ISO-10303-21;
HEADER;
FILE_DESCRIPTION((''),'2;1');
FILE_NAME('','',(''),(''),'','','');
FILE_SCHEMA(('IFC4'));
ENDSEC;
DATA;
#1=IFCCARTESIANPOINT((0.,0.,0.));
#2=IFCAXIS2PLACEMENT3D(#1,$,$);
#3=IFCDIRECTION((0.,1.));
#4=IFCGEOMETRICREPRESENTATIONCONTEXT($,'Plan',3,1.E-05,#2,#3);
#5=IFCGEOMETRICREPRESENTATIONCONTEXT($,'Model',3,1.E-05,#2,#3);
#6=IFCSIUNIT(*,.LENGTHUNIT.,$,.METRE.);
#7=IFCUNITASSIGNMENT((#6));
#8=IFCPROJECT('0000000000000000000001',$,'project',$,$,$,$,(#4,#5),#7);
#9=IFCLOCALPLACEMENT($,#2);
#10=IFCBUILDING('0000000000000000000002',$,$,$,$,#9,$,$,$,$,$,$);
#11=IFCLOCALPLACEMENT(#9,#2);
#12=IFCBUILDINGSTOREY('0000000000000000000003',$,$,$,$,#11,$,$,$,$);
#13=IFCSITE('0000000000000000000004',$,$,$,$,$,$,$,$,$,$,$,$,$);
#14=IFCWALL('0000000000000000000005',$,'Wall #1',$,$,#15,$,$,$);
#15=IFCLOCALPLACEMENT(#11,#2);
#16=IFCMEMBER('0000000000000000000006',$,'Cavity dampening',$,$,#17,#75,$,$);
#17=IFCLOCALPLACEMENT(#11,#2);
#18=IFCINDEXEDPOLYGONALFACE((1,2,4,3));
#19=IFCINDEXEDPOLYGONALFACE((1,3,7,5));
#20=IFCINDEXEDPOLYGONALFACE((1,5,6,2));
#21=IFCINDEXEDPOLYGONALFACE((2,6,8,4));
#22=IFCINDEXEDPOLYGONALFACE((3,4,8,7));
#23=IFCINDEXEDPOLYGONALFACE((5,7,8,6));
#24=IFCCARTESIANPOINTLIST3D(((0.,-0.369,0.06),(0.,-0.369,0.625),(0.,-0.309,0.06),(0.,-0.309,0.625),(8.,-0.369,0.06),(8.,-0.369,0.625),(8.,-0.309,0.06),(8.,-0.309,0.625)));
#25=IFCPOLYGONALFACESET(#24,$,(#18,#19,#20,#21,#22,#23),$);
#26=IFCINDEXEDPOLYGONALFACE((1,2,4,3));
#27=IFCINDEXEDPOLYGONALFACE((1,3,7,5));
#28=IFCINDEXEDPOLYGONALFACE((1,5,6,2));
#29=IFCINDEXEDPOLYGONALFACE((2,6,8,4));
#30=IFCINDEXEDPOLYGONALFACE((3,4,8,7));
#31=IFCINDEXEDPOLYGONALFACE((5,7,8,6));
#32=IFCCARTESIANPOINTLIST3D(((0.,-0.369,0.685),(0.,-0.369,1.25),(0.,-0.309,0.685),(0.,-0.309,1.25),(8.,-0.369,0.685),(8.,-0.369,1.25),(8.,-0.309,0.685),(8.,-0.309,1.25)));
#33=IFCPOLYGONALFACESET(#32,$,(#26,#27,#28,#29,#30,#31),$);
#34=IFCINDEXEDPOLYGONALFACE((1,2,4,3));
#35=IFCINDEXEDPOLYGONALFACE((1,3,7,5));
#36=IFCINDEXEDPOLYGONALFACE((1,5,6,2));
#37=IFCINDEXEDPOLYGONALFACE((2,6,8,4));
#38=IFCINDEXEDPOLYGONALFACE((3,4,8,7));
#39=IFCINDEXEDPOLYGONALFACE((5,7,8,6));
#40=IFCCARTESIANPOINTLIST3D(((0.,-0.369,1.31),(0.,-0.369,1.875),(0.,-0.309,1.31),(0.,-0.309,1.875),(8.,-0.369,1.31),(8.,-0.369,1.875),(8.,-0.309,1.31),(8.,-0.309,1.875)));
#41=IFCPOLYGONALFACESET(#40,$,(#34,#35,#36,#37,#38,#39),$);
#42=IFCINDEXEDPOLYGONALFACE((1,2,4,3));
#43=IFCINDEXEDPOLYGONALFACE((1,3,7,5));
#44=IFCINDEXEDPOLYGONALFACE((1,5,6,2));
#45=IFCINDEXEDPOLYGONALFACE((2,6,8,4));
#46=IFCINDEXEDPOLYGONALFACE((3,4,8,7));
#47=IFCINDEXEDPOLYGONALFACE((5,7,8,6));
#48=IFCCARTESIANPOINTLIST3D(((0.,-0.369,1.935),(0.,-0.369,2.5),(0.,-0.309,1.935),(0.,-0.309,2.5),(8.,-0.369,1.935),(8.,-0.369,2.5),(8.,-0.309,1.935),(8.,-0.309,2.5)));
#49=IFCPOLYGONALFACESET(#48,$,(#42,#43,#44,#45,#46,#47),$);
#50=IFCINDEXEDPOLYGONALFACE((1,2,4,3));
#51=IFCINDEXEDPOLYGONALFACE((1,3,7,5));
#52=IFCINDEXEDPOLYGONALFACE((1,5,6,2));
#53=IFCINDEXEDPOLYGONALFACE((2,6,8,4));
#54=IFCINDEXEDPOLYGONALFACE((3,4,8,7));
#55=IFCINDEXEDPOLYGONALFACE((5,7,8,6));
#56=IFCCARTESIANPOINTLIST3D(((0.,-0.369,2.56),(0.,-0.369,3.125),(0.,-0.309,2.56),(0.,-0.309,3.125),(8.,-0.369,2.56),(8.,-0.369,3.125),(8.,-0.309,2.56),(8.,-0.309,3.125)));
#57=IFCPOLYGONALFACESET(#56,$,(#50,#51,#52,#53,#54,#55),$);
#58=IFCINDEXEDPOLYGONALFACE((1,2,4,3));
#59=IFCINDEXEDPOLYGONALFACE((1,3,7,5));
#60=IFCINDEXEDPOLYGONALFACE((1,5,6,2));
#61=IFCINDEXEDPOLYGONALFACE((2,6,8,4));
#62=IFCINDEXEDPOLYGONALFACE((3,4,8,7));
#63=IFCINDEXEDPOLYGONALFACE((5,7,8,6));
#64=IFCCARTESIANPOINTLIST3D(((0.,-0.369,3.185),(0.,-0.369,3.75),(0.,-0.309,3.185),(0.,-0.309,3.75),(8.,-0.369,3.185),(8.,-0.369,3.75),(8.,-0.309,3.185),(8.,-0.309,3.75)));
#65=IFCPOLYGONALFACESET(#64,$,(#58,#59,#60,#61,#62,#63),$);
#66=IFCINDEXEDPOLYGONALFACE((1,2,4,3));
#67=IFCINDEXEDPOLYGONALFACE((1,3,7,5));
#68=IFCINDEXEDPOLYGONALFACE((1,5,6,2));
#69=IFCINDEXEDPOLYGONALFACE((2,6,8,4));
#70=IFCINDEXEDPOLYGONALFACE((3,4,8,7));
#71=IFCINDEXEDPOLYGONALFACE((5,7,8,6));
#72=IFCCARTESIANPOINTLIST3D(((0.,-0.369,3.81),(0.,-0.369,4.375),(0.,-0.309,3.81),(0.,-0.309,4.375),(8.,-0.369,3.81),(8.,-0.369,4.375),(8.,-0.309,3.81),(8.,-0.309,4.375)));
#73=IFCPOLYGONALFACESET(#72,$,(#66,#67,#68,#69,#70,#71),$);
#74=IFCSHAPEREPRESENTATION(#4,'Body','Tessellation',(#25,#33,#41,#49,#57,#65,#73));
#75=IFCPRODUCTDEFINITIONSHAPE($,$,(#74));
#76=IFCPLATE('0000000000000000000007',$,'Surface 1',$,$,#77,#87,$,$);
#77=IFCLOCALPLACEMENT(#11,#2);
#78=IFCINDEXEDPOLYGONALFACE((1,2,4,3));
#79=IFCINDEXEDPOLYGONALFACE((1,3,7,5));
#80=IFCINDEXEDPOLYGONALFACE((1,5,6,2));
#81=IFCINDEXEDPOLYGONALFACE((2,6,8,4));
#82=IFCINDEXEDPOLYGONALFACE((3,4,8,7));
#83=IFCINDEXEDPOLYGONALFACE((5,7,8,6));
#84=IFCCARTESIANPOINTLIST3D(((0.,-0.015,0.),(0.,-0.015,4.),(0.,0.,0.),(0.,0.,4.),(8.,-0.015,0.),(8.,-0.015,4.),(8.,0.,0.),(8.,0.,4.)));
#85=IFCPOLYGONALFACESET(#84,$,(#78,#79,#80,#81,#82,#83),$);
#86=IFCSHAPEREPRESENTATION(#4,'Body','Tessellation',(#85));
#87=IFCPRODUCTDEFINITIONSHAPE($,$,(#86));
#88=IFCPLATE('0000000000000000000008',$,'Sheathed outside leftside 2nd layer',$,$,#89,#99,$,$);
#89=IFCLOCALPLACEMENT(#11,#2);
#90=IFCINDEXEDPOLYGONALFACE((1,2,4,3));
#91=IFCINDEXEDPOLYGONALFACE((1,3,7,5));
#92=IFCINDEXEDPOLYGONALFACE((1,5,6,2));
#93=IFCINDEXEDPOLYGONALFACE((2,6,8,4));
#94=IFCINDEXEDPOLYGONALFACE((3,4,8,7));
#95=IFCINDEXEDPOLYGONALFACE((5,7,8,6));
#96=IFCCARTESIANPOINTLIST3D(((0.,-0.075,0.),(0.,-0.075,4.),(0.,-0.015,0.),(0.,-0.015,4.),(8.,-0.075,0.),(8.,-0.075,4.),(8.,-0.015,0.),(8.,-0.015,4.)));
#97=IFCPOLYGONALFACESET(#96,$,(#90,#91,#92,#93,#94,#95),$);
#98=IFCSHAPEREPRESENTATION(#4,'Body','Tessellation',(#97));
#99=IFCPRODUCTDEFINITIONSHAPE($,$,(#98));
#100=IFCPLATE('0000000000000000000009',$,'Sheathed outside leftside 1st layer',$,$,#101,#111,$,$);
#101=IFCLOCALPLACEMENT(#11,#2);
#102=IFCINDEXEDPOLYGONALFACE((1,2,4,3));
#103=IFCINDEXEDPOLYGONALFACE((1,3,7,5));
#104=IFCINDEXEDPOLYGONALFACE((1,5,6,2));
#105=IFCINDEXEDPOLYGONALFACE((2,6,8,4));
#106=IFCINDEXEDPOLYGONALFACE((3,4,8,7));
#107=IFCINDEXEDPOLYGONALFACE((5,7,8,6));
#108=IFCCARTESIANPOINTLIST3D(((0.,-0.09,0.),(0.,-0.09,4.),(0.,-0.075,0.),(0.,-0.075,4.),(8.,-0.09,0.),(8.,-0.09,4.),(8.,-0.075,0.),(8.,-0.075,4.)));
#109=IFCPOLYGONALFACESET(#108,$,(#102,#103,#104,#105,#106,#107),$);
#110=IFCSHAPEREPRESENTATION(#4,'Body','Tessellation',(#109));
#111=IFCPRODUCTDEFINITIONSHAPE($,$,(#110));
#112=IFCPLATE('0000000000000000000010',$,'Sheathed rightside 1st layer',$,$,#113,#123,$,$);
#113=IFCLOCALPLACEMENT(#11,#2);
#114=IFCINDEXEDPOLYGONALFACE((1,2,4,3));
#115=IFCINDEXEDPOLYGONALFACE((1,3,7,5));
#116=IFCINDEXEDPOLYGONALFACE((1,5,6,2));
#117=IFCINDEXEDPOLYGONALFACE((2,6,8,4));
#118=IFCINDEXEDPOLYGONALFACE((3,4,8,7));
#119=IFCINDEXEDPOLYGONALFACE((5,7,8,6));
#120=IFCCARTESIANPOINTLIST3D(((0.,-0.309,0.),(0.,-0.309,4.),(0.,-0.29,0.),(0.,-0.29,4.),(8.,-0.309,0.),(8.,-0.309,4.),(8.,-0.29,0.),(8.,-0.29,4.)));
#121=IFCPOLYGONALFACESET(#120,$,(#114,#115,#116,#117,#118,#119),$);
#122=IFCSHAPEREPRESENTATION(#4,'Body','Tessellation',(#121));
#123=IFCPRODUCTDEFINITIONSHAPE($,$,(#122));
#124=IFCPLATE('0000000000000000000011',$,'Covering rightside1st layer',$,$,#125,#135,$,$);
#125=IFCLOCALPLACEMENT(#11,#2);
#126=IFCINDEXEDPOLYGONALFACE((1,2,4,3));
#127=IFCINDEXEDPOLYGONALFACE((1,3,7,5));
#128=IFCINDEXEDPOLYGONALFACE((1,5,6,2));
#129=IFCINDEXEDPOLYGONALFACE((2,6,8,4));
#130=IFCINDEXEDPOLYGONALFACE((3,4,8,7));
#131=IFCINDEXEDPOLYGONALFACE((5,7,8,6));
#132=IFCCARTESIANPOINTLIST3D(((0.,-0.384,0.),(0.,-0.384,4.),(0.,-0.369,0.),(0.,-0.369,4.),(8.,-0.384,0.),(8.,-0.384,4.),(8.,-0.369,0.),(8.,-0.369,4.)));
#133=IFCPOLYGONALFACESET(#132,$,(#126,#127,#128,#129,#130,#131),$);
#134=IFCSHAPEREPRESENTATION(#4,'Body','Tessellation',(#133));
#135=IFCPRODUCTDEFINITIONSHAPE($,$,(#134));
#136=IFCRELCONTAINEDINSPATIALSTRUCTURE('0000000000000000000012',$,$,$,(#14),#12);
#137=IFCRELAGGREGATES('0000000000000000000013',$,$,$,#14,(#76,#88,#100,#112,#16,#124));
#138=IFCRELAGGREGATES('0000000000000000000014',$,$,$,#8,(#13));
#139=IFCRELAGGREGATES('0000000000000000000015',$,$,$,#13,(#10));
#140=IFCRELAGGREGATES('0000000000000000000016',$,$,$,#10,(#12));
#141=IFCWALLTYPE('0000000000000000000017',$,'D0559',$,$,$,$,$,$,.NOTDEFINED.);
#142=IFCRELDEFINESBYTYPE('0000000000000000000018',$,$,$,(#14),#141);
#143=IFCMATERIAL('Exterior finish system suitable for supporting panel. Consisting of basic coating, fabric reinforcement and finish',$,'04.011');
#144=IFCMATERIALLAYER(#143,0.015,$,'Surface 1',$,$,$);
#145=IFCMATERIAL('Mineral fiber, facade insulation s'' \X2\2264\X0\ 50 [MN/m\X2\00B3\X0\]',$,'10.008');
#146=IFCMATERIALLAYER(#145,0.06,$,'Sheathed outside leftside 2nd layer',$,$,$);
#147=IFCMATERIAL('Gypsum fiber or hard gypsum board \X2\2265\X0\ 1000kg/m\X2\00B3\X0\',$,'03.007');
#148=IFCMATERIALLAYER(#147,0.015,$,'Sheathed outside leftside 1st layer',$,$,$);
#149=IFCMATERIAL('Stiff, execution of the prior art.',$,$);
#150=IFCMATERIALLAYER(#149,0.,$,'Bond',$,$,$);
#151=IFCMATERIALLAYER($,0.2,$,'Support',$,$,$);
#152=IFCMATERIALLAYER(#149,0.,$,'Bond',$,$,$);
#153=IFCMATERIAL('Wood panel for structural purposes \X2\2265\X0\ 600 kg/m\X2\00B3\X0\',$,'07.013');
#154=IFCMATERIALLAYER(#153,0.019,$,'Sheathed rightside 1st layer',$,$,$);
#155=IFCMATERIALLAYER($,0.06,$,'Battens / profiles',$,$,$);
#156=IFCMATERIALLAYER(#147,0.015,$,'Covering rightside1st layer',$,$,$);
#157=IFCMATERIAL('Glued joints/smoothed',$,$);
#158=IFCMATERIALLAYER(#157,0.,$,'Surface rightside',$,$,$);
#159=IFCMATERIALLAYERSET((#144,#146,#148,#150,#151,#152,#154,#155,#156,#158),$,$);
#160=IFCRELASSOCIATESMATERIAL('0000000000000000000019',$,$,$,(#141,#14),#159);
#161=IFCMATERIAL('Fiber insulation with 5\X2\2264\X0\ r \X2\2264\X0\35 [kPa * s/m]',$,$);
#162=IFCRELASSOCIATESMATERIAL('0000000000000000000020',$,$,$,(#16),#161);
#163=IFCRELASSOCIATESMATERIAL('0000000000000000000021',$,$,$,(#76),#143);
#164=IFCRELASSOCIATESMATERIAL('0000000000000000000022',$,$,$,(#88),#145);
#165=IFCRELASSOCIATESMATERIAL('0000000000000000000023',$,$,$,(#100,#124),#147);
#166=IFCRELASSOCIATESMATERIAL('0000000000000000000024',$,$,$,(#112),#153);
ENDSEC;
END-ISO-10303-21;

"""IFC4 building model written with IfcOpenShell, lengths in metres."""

from ifc_helpers import new_model, si_unit, direction, frame, frame_2d, origin, origin_with_axes, place, context, project, spatial, rectangle, extrude, material, layer, layer_set, type_object, element, aggregate, save


model = new_model("IFC4")

# Units and contexts
plan_context = context("Plan", 3, precision=1e-05, world=origin(), true_north=direction((0.0, 1.0)))
model_context = context("Model", 3, precision=1e-05, world=origin(), true_north=direction((0.0, 1.0)))
ifc_project = project(units=[si_unit("LENGTHUNIT", "METRE")], contexts=[plan_context, model_context])

# Site, building, storey
site = spatial("IfcSite", under=ifc_project)
building_placement = place(None, origin())
building = spatial("IfcBuilding", under=site, at=building_placement)
storey_placement = place(building_placement, origin())
storey = spatial("IfcBuildingStorey", under=building, at=storey_placement)

# Wall, member, plates
ifc_material_1 = material(Name="Exterior finish system suitable for supporting panel. Consisting of basic coating, fabric reinforcement and finish", Category="04.011")
ifc_layer_1 = layer(ifc_material_1, 0.015, Name="Surface 1")
ifc_material_2 = material(Name="Mineral fiber, facade insulation s' ≤ 50 [MN/m³]", Category="10.008")
ifc_layer_2 = layer(ifc_material_2, 0.06, Name="Sheathed outside leftside 2nd layer")
ifc_material_3 = material(Name="Gypsum fiber or hard gypsum board ≥ 1000kg/m³", Category="03.007")
ifc_layer_3 = layer(ifc_material_3, 0.015, Name="Sheathed outside leftside 1st layer")
ifc_material_4 = material(Name="Stiff, execution of the prior art.")
ifc_layer_4 = layer(ifc_material_4, 0.0, Name="Bond")
ifc_layer_5 = layer(None, 0.2, Name="Support")
ifc_layer_6 = layer(ifc_material_4, 0.0, Name="Bond")
ifc_material_5 = material(Name="Wood panel for structural purposes ≥ 600 kg/m³", Category="07.013")
ifc_layer_7 = layer(ifc_material_5, 0.019, Name="Sheathed rightside 1st layer")
ifc_layer_8 = layer(None, 0.06, Name="Battens / profiles")
ifc_layer_9 = layer(ifc_material_3, 0.015, Name="Covering rightside1st layer")
ifc_material_6 = material(Name="Glued joints/smoothed")
ifc_layer_10 = layer(ifc_material_6, 0.0, Name="Surface rightside")
ifc_layer_set = layer_set([ifc_layer_1, ifc_layer_2, ifc_layer_3, ifc_layer_4, ifc_layer_5, ifc_layer_6, ifc_layer_7, ifc_layer_8, ifc_layer_9, ifc_layer_10])
wall_type = type_object("IfcWallType", Name="D0559", PredefinedType="NOTDEFINED", material=ifc_layer_set)
wall_placement = place(None, frame((0.0, 0.0, 0.0), z_axis=(0.0, -1.0, 0.0), x_axis=(1.0, 0.0, 0.0)))
wall = element("IfcWall", 1, at=wall_placement, inside=storey, type_object=wall_type, material=ifc_layer_set, Name="Wall #1")
ifc_material_7 = material(Name="Fiber insulation with 5≤ r ≤35 [kPa * s/m]")
member_1_placement = place(wall_placement, origin())
member_1 = element("IfcMember", 2, at=member_1_placement, material=ifc_material_7, Name="Cavity dampening", context=plan_context, shape_type="SweptSolid", body=[
    extrude(rectangle(XDim=0.565, YDim=0.06, at=frame_2d((0.2825, 0.03), x_axis=(1.0, 0.0))), frame((0.0, 0.06, 0.309), z_axis=(1.0, 0.0, 0.0), x_axis=(0.0, 1.0, 0.0)), (0.0, 0.0, 1.0), 8.0),
    extrude(rectangle(XDim=0.565, YDim=0.06, at=frame_2d((0.2825, 0.03), x_axis=(1.0, 0.0))), frame((0.0, 0.685, 0.309), z_axis=(1.0, 0.0, 0.0), x_axis=(0.0, 1.0, 0.0)), (0.0, 0.0, 1.0), 8.0),
    extrude(rectangle(XDim=0.565, YDim=0.06, at=frame_2d((0.2825, 0.03), x_axis=(1.0, 0.0))), frame((0.0, 1.31, 0.309), z_axis=(1.0, 0.0, 0.0), x_axis=(0.0, 1.0, 0.0)), (0.0, 0.0, 1.0), 8.0),
    extrude(rectangle(XDim=0.565, YDim=0.06, at=frame_2d((0.2825, 0.03), x_axis=(1.0, 0.0))), frame((0.0, 1.935, 0.309), z_axis=(1.0, 0.0, 0.0), x_axis=(0.0, 1.0, 0.0)), (0.0, 0.0, 1.0), 8.0),
    extrude(rectangle(XDim=0.565, YDim=0.06, at=frame_2d((0.2825, 0.03), x_axis=(1.0, 0.0))), frame((0.0, 2.56, 0.309), z_axis=(1.0, 0.0, 0.0), x_axis=(0.0, 1.0, 0.0)), (0.0, 0.0, 1.0), 8.0),
    extrude(rectangle(XDim=0.565, YDim=0.06, at=frame_2d((0.2825, 0.03), x_axis=(1.0, 0.0))), frame((0.0, 3.185, 0.309), z_axis=(1.0, 0.0, 0.0), x_axis=(0.0, 1.0, 0.0)), (0.0, 0.0, 1.0), 8.0),
    extrude(rectangle(XDim=0.565, YDim=0.06, at=frame_2d((0.2825, 0.03), x_axis=(1.0, 0.0))), frame((0.0, 3.81, 0.309), z_axis=(1.0, 0.0, 0.0), x_axis=(0.0, 1.0, 0.0)), (0.0, 0.0, 1.0), 8.0),
])
plate_1_placement = place(wall_placement, origin())
plate_1 = element("IfcPlate", 3, at=plate_1_placement, material=ifc_material_1, Name="Surface 1", context=plan_context, shape_type="SweptSolid", body=[
    extrude(rectangle(XDim=8.0, YDim=4.0, at=frame_2d((4.0, 2.0), x_axis=(1.0, 0.0))), origin_with_axes(), (0.0, 0.0, 1.0), 0.015),
])
plate_2_placement = place(wall_placement, origin())
plate_2 = element("IfcPlate", 4, at=plate_2_placement, material=ifc_material_2, Name="Sheathed outside leftside 2nd layer", context=plan_context, shape_type="SweptSolid", body=[
    extrude(rectangle(XDim=8.0, YDim=4.0, at=frame_2d((4.0, 2.0), x_axis=(1.0, 0.0))), frame((0.0, 0.0, 0.015), z_axis=(0.0, 0.0, 1.0), x_axis=(1.0, 0.0, 0.0)), (0.0, 0.0, 1.0), 0.06),
])
plate_3_placement = place(wall_placement, origin())
plate_3 = element("IfcPlate", 5, at=plate_3_placement, material=ifc_material_3, Name="Sheathed outside leftside 1st layer", context=plan_context, shape_type="SweptSolid", body=[
    extrude(rectangle(XDim=8.0, YDim=4.0, at=frame_2d((4.0, 2.0), x_axis=(1.0, 0.0))), frame((0.0, 0.0, 0.075), z_axis=(0.0, 0.0, 1.0), x_axis=(1.0, 0.0, 0.0)), (0.0, 0.0, 1.0), 0.015),
])
plate_4_placement = place(wall_placement, origin())
plate_4 = element("IfcPlate", 6, at=plate_4_placement, material=ifc_material_5, Name="Sheathed rightside 1st layer", context=plan_context, shape_type="SweptSolid", body=[
    extrude(rectangle(XDim=8.0, YDim=4.0, at=frame_2d((4.0, 2.0), x_axis=(1.0, 0.0))), frame((0.0, 0.0, 0.29), z_axis=(0.0, 0.0, 1.0), x_axis=(1.0, 0.0, 0.0)), (0.0, 0.0, 1.0), 0.019),
])
plate_5_placement = place(wall_placement, origin())
plate_5 = element("IfcPlate", 7, at=plate_5_placement, material=ifc_material_3, Name="Covering rightside1st layer", context=plan_context, shape_type="SweptSolid", body=[
    extrude(rectangle(XDim=8.0, YDim=4.0, at=frame_2d((4.0, 2.0), x_axis=(1.0, 0.0))), frame((0.0, 0.0, 0.369), z_axis=(0.0, 0.0, 1.0), x_axis=(1.0, 0.0, 0.0)), (0.0, 0.0, 1.0), 0.015),
])
aggregate(wall, [plate_1, plate_2, plate_3, plate_4, member_1, plate_5])

save(model, "model.ifc")
